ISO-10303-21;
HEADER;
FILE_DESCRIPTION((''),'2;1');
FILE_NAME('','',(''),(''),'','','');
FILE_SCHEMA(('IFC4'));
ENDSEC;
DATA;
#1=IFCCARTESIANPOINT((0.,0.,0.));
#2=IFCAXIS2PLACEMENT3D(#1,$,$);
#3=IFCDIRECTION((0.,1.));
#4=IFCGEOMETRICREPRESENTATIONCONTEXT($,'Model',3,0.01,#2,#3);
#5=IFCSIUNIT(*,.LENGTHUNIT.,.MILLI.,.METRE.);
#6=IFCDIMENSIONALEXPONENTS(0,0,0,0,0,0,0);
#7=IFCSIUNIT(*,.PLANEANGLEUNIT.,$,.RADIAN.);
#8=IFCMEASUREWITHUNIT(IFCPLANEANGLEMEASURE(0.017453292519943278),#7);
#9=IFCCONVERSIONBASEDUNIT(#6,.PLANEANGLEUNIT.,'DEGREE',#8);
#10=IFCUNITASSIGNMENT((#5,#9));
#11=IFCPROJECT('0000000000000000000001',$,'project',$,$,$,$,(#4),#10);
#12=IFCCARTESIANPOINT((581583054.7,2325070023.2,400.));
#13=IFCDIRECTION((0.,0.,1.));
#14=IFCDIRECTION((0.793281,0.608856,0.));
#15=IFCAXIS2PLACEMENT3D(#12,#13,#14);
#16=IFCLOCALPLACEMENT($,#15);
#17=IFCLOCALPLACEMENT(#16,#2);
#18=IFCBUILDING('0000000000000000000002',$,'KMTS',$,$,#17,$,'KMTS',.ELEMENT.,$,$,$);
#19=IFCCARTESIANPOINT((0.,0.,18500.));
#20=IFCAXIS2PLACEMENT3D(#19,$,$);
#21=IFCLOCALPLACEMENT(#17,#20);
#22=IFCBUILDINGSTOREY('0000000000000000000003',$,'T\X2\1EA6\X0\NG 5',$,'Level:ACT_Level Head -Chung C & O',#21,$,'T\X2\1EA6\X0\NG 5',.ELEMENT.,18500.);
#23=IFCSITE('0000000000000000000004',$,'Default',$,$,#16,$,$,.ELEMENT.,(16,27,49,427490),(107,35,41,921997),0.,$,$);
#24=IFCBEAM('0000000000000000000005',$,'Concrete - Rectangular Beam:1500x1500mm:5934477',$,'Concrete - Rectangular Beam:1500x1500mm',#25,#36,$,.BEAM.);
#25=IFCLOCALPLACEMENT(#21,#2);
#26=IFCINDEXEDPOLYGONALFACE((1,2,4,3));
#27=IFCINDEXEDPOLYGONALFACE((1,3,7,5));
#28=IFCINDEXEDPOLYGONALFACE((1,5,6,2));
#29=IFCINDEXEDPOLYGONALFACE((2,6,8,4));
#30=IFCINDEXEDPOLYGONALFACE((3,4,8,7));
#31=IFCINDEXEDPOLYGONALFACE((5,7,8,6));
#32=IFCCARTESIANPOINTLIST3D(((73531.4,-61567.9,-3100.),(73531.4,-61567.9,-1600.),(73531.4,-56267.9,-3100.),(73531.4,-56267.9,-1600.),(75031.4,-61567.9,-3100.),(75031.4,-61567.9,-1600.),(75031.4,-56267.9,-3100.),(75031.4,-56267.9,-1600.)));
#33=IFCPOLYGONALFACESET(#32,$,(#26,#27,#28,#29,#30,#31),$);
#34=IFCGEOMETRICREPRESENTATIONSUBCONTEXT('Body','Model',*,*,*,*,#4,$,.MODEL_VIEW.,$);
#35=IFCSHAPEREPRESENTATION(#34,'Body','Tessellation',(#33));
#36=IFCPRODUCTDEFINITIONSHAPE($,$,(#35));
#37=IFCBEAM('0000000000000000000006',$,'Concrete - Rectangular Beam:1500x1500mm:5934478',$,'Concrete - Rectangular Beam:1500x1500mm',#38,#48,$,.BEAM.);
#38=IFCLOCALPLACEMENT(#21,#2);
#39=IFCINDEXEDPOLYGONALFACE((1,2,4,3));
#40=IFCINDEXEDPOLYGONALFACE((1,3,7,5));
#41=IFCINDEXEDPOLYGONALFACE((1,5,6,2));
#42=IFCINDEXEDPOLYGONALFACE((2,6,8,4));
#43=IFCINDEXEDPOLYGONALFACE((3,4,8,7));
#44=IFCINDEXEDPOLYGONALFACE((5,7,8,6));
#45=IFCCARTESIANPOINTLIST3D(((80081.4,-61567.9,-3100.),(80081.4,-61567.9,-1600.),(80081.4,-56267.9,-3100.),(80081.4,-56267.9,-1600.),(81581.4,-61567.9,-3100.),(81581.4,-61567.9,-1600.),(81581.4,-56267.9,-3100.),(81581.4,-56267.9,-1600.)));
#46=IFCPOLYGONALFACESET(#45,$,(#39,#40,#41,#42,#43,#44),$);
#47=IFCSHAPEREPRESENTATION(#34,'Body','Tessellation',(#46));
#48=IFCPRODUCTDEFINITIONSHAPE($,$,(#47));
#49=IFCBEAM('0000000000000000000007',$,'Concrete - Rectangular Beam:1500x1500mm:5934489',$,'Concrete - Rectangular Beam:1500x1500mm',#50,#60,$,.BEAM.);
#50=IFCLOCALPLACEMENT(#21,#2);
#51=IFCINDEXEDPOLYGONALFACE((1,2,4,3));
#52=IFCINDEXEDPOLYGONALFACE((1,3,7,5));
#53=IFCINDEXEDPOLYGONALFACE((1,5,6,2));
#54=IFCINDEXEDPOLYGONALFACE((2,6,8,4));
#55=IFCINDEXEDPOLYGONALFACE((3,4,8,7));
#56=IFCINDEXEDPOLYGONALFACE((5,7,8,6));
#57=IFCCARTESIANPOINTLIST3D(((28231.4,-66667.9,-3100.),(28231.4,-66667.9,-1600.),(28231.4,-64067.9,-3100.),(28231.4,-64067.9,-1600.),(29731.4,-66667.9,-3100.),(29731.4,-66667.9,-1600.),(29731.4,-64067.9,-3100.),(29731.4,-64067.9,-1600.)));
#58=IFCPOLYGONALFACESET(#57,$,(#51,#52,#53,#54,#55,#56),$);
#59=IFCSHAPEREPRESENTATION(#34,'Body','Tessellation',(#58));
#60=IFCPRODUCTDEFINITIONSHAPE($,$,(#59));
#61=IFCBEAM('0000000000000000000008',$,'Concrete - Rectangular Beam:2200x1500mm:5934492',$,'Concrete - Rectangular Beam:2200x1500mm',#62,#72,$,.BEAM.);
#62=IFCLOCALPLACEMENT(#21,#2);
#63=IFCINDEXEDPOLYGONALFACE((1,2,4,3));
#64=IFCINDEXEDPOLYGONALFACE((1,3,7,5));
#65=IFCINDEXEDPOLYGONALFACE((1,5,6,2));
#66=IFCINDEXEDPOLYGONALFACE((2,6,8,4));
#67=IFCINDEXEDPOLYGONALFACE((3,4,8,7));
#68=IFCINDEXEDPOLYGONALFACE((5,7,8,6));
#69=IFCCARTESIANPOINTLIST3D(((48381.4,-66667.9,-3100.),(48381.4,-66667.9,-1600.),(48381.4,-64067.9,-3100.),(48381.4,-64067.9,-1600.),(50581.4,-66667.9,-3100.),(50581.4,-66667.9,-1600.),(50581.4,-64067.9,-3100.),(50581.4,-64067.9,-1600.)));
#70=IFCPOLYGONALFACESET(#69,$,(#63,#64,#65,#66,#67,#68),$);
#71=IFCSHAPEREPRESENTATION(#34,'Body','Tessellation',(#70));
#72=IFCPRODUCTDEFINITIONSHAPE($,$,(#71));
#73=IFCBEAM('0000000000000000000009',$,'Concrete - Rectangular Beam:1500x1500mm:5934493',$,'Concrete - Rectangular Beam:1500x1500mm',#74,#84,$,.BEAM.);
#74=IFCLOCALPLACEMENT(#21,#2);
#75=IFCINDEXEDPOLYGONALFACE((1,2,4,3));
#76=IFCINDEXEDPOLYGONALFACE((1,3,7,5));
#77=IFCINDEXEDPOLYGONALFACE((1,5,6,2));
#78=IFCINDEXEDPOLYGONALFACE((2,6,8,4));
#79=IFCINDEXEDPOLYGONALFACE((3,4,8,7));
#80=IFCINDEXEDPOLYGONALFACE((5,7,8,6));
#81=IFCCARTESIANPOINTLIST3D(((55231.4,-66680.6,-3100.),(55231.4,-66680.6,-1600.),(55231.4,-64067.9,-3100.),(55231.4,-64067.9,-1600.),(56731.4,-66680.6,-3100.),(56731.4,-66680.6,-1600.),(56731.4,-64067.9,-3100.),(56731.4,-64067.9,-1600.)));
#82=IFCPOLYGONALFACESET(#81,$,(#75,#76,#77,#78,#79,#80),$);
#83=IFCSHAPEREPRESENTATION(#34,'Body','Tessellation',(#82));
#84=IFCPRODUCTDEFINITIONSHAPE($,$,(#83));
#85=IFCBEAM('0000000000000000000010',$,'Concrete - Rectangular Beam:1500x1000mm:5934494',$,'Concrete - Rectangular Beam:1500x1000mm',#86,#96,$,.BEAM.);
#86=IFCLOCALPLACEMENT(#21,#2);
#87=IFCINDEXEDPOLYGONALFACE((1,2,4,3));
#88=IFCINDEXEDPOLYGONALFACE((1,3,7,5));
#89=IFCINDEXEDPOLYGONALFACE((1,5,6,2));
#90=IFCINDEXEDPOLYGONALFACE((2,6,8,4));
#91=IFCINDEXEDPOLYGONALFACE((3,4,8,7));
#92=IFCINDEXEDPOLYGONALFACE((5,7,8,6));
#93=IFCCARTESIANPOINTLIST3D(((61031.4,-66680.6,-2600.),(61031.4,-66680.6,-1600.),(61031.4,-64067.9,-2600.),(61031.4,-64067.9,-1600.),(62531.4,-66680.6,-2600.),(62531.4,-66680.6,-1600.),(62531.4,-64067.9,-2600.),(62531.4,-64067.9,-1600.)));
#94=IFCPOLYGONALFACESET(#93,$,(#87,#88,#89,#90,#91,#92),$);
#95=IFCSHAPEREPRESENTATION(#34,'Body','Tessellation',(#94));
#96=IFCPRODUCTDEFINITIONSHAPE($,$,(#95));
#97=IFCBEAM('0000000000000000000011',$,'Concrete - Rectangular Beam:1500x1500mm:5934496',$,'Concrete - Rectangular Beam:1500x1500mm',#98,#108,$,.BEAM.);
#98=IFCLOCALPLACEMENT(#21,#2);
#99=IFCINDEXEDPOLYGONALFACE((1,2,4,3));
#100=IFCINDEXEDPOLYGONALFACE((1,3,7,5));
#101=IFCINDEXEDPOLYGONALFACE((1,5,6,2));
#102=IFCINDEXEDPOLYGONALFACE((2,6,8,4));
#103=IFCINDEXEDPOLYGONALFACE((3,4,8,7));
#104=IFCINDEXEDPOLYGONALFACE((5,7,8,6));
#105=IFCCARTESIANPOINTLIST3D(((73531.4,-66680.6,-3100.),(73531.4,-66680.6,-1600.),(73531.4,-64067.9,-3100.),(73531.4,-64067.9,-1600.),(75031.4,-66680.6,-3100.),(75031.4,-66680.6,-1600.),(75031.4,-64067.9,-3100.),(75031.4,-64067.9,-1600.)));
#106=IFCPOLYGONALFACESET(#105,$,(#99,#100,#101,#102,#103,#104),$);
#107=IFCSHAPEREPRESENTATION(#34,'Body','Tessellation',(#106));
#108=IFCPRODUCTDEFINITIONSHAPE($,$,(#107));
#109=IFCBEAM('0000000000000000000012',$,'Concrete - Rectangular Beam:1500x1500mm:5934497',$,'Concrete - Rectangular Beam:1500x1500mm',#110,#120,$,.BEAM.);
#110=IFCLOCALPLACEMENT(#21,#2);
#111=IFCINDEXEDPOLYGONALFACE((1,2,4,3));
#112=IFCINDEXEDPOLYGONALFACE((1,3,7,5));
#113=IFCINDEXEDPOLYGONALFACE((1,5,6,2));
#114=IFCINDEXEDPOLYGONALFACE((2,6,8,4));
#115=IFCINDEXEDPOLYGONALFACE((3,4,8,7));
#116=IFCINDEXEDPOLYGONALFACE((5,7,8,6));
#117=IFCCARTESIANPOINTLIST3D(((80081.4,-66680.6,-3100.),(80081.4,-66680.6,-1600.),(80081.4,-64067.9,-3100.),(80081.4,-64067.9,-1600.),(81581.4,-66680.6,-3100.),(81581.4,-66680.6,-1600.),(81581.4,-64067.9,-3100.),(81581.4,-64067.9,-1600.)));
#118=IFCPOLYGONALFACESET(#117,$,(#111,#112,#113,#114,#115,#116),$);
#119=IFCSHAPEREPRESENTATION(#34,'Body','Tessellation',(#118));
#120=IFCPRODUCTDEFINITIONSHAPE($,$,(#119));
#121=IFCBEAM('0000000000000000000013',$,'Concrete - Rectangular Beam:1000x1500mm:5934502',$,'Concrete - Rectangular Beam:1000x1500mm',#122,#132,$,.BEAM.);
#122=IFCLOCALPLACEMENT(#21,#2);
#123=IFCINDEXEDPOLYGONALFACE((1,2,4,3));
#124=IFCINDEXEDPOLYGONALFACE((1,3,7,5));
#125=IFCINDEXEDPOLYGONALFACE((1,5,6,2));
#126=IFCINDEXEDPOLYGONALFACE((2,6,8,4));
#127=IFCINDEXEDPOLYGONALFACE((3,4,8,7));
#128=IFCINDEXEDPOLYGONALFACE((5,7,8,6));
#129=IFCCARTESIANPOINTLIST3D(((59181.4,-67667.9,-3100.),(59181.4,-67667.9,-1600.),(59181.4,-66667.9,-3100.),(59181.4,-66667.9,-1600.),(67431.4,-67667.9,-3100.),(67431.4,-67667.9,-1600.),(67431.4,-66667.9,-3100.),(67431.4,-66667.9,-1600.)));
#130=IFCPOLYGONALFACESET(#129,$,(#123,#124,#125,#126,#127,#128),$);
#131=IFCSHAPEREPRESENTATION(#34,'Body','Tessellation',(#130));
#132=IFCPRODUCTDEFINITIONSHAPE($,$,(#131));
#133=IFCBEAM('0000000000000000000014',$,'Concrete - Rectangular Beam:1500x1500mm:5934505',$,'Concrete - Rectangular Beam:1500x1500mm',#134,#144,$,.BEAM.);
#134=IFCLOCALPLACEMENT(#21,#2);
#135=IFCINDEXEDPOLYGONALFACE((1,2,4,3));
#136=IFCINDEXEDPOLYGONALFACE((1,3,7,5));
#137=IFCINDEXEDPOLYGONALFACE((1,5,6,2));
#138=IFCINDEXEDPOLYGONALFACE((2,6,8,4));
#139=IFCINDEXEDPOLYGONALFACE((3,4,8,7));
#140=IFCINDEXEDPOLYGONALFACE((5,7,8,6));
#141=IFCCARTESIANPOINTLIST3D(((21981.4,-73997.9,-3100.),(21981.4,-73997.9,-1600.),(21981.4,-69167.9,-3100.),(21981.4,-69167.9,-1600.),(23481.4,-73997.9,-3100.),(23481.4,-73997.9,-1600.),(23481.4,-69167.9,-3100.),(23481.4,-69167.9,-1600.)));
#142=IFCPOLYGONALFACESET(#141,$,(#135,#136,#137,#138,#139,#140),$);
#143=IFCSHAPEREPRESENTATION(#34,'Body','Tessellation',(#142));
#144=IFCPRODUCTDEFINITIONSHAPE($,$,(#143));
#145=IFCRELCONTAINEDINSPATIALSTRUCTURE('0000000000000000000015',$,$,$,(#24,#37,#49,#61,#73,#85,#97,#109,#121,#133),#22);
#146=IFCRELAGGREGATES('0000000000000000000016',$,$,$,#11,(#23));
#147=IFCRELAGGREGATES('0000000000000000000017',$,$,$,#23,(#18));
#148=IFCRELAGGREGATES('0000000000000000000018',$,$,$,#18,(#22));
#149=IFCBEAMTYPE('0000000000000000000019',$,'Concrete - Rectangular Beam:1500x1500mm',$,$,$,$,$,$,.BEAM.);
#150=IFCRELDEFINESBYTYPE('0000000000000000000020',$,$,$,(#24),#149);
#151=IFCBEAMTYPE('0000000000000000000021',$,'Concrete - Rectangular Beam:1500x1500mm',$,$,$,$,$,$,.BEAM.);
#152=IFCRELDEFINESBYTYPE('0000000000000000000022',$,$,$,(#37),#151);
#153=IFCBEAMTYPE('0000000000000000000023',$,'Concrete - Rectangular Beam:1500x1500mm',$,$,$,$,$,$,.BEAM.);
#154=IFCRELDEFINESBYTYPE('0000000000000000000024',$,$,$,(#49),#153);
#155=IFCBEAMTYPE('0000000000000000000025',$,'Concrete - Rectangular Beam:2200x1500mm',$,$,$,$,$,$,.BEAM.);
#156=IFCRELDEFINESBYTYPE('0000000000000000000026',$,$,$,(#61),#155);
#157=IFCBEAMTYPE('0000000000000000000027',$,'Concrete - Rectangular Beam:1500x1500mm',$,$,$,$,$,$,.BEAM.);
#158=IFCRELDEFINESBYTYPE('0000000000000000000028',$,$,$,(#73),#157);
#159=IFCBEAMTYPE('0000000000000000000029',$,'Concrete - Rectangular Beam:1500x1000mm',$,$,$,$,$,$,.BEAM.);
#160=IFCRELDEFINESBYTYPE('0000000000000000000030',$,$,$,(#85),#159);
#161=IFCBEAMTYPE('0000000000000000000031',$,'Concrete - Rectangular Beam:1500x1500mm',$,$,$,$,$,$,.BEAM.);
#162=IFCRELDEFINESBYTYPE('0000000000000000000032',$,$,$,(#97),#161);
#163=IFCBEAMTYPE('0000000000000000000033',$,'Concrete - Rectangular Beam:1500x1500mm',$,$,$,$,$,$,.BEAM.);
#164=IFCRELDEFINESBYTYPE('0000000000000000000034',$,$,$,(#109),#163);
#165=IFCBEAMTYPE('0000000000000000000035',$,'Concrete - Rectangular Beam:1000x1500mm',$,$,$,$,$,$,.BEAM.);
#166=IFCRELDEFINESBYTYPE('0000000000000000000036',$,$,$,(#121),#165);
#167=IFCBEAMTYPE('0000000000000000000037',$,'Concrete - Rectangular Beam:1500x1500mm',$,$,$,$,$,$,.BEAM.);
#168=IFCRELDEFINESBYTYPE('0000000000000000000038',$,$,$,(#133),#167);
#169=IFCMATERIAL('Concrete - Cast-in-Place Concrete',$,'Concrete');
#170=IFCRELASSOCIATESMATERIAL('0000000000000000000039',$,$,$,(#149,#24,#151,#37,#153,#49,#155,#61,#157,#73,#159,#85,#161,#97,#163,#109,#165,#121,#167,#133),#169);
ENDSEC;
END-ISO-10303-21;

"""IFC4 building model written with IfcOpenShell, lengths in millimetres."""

from ifc_helpers import new_model, entity, si_unit, converted_unit, direction, frame, origin, place, context, subcontext, project, spatial, indexed_curve, outline, extrude, source, transform, mapped, material, type_object, type_shapes, element, save


model = new_model("IFC4")

# Units and contexts
model_context = context("Model", 3, precision=0.01, world=origin(), true_north=direction((0.0, 1.0)))
body_context = subcontext(model_context, "Body", "Model", "MODEL_VIEW")
ifc_project = project(units=[si_unit("LENGTHUNIT", "METRE", prefix="MILLI"), converted_unit("PLANEANGLEUNIT", "DEGREE", entity("IfcPlaneAngleMeasure", 0.017453292519943278), si_unit("PLANEANGLEUNIT", "RADIAN"), dimensions=[0, 0, 0, 0, 0, 0, 0])], contexts=[model_context])

# Site, building, storey
site_placement = place(None, frame((581583054.7, 2325070023.2, 400.0), z_axis=(0.0, 0.0, 1.0), x_axis=(0.793281, 0.608856, 0.0)))
site = spatial("IfcSite", under=ifc_project, at=site_placement, Name="Default", CompositionType="ELEMENT", RefLatitude=(16, 27, 49, 427490), RefLongitude=(107, 35, 41, 921997), RefElevation=0.0)
building_placement = place(site_placement, origin())
building = spatial("IfcBuilding", under=site, at=building_placement, Name="KMTS", LongName="KMTS", CompositionType="ELEMENT")
storey_placement = place(building_placement, frame((0.0, 0.0, 18500.0)))
storey = spatial("IfcBuildingStorey", under=building, at=storey_placement, Name="TẦNG 5", ObjectType="Level:ACT_Level Head -Chung C & O", LongName="TẦNG 5", CompositionType="ELEMENT", Elevation=18500.0)

# Beams
ifc_material_1 = material(Name="Concrete - Cast-in-Place Concrete", Category="Concrete")
beam_type_1 = type_object("IfcBeamType", Name="Concrete - Rectangular Beam:1500x1500mm", PredefinedType="BEAM", material=ifc_material_1)
shared_shape_1 = source(origin(), body_context, "Body", "SweptSolid", [
    extrude(outline(indexed_curve([(-750.0, -750.0), (750.0, -750.0), (750.0, 750.0), (-750.0, 750.0), (-750.0, -750.0)], self_intersect=False)), frame((74281.4, -61567.9, 16150.0), z_axis=(0.0, 1.0, 0.0), x_axis=(-1.0, 0.0, 0.0)), (0.0, 0.0, 1.0), 5300.0),
])
type_shapes(beam_type_1, [shared_shape_1])
beam_1_placement = place(storey_placement, frame((0.0, 0.0, -18500.0)))
element("IfcBeam", 1, at=beam_1_placement, inside=storey, type_object=beam_type_1, material=ifc_material_1, Name="Concrete - Rectangular Beam:1500x1500mm:5934477", ObjectType="Concrete - Rectangular Beam:1500x1500mm", PredefinedType="BEAM", context=body_context, shape_type="MappedRepresentation", body=[
    mapped(shared_shape_1, transform((0.0, 0.0, 0.0), scale=1.0)),
])
beam_type_2 = type_object("IfcBeamType", Name="Concrete - Rectangular Beam:1500x1500mm", PredefinedType="BEAM", material=ifc_material_1)
shared_shape_2 = source(origin(), body_context, "Body", "SweptSolid", [
    extrude(outline(indexed_curve([(-750.0, -750.0), (750.0, -750.0), (750.0, 750.0), (-750.0, 750.0), (-750.0, -750.0)], self_intersect=False)), frame((80831.4, -56267.9, 16150.0), z_axis=(0.0, -1.0, 0.0), x_axis=(-1.0, 0.0, 0.0)), (0.0, 0.0, 1.0), 5300.0),
])
type_shapes(beam_type_2, [shared_shape_2])
beam_2_placement = place(storey_placement, frame((0.0, 0.0, -18500.0)))
element("IfcBeam", 2, at=beam_2_placement, inside=storey, type_object=beam_type_2, material=ifc_material_1, Name="Concrete - Rectangular Beam:1500x1500mm:5934478", ObjectType="Concrete - Rectangular Beam:1500x1500mm", PredefinedType="BEAM", context=body_context, shape_type="MappedRepresentation", body=[
    mapped(shared_shape_2, transform((0.0, 0.0, 0.0), scale=1.0)),
])
beam_type_3 = type_object("IfcBeamType", Name="Concrete - Rectangular Beam:1500x1500mm", PredefinedType="BEAM", material=ifc_material_1)
shared_shape_3 = source(origin(), body_context, "Body", "SweptSolid", [
    extrude(outline(indexed_curve([(-750.0, -750.0), (750.0, -750.0), (750.0, 750.0), (-750.0, 750.0), (-750.0, -750.0)], self_intersect=False)), frame((28981.4, -66667.9, 16150.0), z_axis=(0.0, 1.0, 0.0), x_axis=(-1.0, 0.0, 0.0)), (0.0, 0.0, 1.0), 2600.0),
])
type_shapes(beam_type_3, [shared_shape_3])
beam_3_placement = place(storey_placement, frame((0.0, 0.0, -18500.0)))
element("IfcBeam", 3, at=beam_3_placement, inside=storey, type_object=beam_type_3, material=ifc_material_1, Name="Concrete - Rectangular Beam:1500x1500mm:5934489", ObjectType="Concrete - Rectangular Beam:1500x1500mm", PredefinedType="BEAM", context=body_context, shape_type="MappedRepresentation", body=[
    mapped(shared_shape_3, transform((0.0, 0.0, 0.0), scale=1.0)),
])
beam_type_4 = type_object("IfcBeamType", Name="Concrete - Rectangular Beam:2200x1500mm", PredefinedType="BEAM", material=ifc_material_1)
shared_shape_4 = source(origin(), body_context, "Body", "SweptSolid", [
    extrude(outline(indexed_curve([(-1100.0, -750.0), (1100.0, -750.0), (1100.0, 750.0), (-1100.0, 750.0), (-1100.0, -750.0)], self_intersect=False)), frame((49481.4, -66667.9, 16150.0), z_axis=(0.0, 1.0, 0.0), x_axis=(-1.0, 0.0, 0.0)), (0.0, 0.0, 1.0), 2600.0),
])
type_shapes(beam_type_4, [shared_shape_4])
beam_4_placement = place(storey_placement, frame((0.0, 0.0, -18500.0)))
element("IfcBeam", 4, at=beam_4_placement, inside=storey, type_object=beam_type_4, material=ifc_material_1, Name="Concrete - Rectangular Beam:2200x1500mm:5934492", ObjectType="Concrete - Rectangular Beam:2200x1500mm", PredefinedType="BEAM", context=body_context, shape_type="MappedRepresentation", body=[
    mapped(shared_shape_4, transform((0.0, 0.0, 0.0), scale=1.0)),
])
beam_type_5 = type_object("IfcBeamType", Name="Concrete - Rectangular Beam:1500x1500mm", PredefinedType="BEAM", material=ifc_material_1)
shared_shape_5 = source(origin(), body_context, "Body", "SweptSolid", [
    extrude(outline(indexed_curve([(-750.0, -750.0), (750.0, -750.0), (750.0, 750.0), (-750.0, 750.0), (-750.0, -750.0)], self_intersect=False)), frame((55981.4, -66680.6, 16150.0), z_axis=(0.0, 1.0, 0.0), x_axis=(-1.0, 0.0, 0.0)), (0.0, 0.0, 1.0), 2612.7),
])
type_shapes(beam_type_5, [shared_shape_5])
beam_5_placement = place(storey_placement, frame((0.0, 0.0, -18500.0)))
element("IfcBeam", 5, at=beam_5_placement, inside=storey, type_object=beam_type_5, material=ifc_material_1, Name="Concrete - Rectangular Beam:1500x1500mm:5934493", ObjectType="Concrete - Rectangular Beam:1500x1500mm", PredefinedType="BEAM", context=body_context, shape_type="MappedRepresentation", body=[
    mapped(shared_shape_5, transform((0.0, 0.0, 0.0), scale=1.0)),
])
beam_type_6 = type_object("IfcBeamType", Name="Concrete - Rectangular Beam:1500x1000mm", PredefinedType="BEAM", material=ifc_material_1)
shared_shape_6 = source(origin(), body_context, "Body", "SweptSolid", [
    extrude(outline(indexed_curve([(-750.0, -500.0), (750.0, -500.0), (750.0, 500.0), (-750.0, 500.0), (-750.0, -500.0)], self_intersect=False)), frame((61781.4, -66680.6, 16400.0), z_axis=(0.0, 1.0, 0.0), x_axis=(-1.0, 0.0, 0.0)), (0.0, 0.0, 1.0), 2612.7),
])
type_shapes(beam_type_6, [shared_shape_6])
beam_6_placement = place(storey_placement, frame((0.0, 0.0, -18500.0)))
element("IfcBeam", 6, at=beam_6_placement, inside=storey, type_object=beam_type_6, material=ifc_material_1, Name="Concrete - Rectangular Beam:1500x1000mm:5934494", ObjectType="Concrete - Rectangular Beam:1500x1000mm", PredefinedType="BEAM", context=body_context, shape_type="MappedRepresentation", body=[
    mapped(shared_shape_6, transform((0.0, 0.0, 0.0), scale=1.0)),
])
beam_type_7 = type_object("IfcBeamType", Name="Concrete - Rectangular Beam:1500x1500mm", PredefinedType="BEAM", material=ifc_material_1)
shared_shape_7 = source(origin(), body_context, "Body", "SweptSolid", [
    extrude(outline(indexed_curve([(-750.0, -750.0), (750.0, -750.0), (750.0, 750.0), (-750.0, 750.0), (-750.0, -750.0)], self_intersect=False)), frame((74281.4, -66680.6, 16150.0), z_axis=(0.0, 1.0, 0.0), x_axis=(-1.0, 0.0, 0.0)), (0.0, 0.0, 1.0), 2612.7),
])
type_shapes(beam_type_7, [shared_shape_7])
beam_7_placement = place(storey_placement, frame((0.0, 0.0, -18500.0)))
element("IfcBeam", 7, at=beam_7_placement, inside=storey, type_object=beam_type_7, material=ifc_material_1, Name="Concrete - Rectangular Beam:1500x1500mm:5934496", ObjectType="Concrete - Rectangular Beam:1500x1500mm", PredefinedType="BEAM", context=body_context, shape_type="MappedRepresentation", body=[
    mapped(shared_shape_7, transform((0.0, 0.0, 0.0), scale=1.0)),
])
beam_type_8 = type_object("IfcBeamType", Name="Concrete - Rectangular Beam:1500x1500mm", PredefinedType="BEAM", material=ifc_material_1)
shared_shape_8 = source(origin(), body_context, "Body", "SweptSolid", [
    extrude(outline(indexed_curve([(-750.0, -750.0), (750.0, -750.0), (750.0, 750.0), (-750.0, 750.0), (-750.0, -750.0)], self_intersect=False)), frame((80831.4, -64067.9, 16150.0), z_axis=(0.0, -1.0, 0.0), x_axis=(-1.0, 0.0, 0.0)), (0.0, 0.0, 1.0), 2612.7),
])
type_shapes(beam_type_8, [shared_shape_8])
beam_8_placement = place(storey_placement, frame((0.0, 0.0, -18500.0)))
element("IfcBeam", 8, at=beam_8_placement, inside=storey, type_object=beam_type_8, material=ifc_material_1, Name="Concrete - Rectangular Beam:1500x1500mm:5934497", ObjectType="Concrete - Rectangular Beam:1500x1500mm", PredefinedType="BEAM", context=body_context, shape_type="MappedRepresentation", body=[
    mapped(shared_shape_8, transform((0.0, 0.0, 0.0), scale=1.0)),
])
beam_type_9 = type_object("IfcBeamType", Name="Concrete - Rectangular Beam:1000x1500mm", PredefinedType="BEAM", material=ifc_material_1)
shared_shape_9 = source(origin(), body_context, "Body", "SweptSolid", [
    extrude(outline(indexed_curve([(-750.0, -500.0), (750.0, -500.0), (750.0, 500.0), (-750.0, 500.0), (-750.0, -500.0)], self_intersect=False)), frame((59181.4, -67167.9, 16150.0), z_axis=(1.0, 0.0, 0.0), x_axis=(0.0, 0.0, -1.0)), (0.0, 0.0, 1.0), 8250.0),
])
type_shapes(beam_type_9, [shared_shape_9])
beam_9_placement = place(storey_placement, frame((0.0, 0.0, -18500.0)))
element("IfcBeam", 9, at=beam_9_placement, inside=storey, type_object=beam_type_9, material=ifc_material_1, Name="Concrete - Rectangular Beam:1000x1500mm:5934502", ObjectType="Concrete - Rectangular Beam:1000x1500mm", PredefinedType="BEAM", context=body_context, shape_type="MappedRepresentation", body=[
    mapped(shared_shape_9, transform((0.0, 0.0, 0.0), scale=1.0)),
])
beam_type_10 = type_object("IfcBeamType", Name="Concrete - Rectangular Beam:1500x1500mm", PredefinedType="BEAM", material=ifc_material_1)
shared_shape_10 = source(origin(), body_context, "Body", "SweptSolid", [
    extrude(outline(indexed_curve([(-750.0, -750.0), (750.0, -750.0), (750.0, 750.0), (-750.0, 750.0), (-750.0, -750.0)], self_intersect=False)), frame((22731.4, -73997.9, 16150.0), z_axis=(0.0, 1.0, 0.0), x_axis=(-1.0, 0.0, 0.0)), (0.0, 0.0, 1.0), 4830.0),
])
type_shapes(beam_type_10, [shared_shape_10])
beam_10_placement = place(storey_placement, frame((0.0, 0.0, -18500.0)))
element("IfcBeam", 10, at=beam_10_placement, inside=storey, type_object=beam_type_10, material=ifc_material_1, Name="Concrete - Rectangular Beam:1500x1500mm:5934505", ObjectType="Concrete - Rectangular Beam:1500x1500mm", PredefinedType="BEAM", context=body_context, shape_type="MappedRepresentation", body=[
    mapped(shared_shape_10, transform((0.0, 0.0, 0.0), scale=1.0)),
])

save(model, "model.ifc")
